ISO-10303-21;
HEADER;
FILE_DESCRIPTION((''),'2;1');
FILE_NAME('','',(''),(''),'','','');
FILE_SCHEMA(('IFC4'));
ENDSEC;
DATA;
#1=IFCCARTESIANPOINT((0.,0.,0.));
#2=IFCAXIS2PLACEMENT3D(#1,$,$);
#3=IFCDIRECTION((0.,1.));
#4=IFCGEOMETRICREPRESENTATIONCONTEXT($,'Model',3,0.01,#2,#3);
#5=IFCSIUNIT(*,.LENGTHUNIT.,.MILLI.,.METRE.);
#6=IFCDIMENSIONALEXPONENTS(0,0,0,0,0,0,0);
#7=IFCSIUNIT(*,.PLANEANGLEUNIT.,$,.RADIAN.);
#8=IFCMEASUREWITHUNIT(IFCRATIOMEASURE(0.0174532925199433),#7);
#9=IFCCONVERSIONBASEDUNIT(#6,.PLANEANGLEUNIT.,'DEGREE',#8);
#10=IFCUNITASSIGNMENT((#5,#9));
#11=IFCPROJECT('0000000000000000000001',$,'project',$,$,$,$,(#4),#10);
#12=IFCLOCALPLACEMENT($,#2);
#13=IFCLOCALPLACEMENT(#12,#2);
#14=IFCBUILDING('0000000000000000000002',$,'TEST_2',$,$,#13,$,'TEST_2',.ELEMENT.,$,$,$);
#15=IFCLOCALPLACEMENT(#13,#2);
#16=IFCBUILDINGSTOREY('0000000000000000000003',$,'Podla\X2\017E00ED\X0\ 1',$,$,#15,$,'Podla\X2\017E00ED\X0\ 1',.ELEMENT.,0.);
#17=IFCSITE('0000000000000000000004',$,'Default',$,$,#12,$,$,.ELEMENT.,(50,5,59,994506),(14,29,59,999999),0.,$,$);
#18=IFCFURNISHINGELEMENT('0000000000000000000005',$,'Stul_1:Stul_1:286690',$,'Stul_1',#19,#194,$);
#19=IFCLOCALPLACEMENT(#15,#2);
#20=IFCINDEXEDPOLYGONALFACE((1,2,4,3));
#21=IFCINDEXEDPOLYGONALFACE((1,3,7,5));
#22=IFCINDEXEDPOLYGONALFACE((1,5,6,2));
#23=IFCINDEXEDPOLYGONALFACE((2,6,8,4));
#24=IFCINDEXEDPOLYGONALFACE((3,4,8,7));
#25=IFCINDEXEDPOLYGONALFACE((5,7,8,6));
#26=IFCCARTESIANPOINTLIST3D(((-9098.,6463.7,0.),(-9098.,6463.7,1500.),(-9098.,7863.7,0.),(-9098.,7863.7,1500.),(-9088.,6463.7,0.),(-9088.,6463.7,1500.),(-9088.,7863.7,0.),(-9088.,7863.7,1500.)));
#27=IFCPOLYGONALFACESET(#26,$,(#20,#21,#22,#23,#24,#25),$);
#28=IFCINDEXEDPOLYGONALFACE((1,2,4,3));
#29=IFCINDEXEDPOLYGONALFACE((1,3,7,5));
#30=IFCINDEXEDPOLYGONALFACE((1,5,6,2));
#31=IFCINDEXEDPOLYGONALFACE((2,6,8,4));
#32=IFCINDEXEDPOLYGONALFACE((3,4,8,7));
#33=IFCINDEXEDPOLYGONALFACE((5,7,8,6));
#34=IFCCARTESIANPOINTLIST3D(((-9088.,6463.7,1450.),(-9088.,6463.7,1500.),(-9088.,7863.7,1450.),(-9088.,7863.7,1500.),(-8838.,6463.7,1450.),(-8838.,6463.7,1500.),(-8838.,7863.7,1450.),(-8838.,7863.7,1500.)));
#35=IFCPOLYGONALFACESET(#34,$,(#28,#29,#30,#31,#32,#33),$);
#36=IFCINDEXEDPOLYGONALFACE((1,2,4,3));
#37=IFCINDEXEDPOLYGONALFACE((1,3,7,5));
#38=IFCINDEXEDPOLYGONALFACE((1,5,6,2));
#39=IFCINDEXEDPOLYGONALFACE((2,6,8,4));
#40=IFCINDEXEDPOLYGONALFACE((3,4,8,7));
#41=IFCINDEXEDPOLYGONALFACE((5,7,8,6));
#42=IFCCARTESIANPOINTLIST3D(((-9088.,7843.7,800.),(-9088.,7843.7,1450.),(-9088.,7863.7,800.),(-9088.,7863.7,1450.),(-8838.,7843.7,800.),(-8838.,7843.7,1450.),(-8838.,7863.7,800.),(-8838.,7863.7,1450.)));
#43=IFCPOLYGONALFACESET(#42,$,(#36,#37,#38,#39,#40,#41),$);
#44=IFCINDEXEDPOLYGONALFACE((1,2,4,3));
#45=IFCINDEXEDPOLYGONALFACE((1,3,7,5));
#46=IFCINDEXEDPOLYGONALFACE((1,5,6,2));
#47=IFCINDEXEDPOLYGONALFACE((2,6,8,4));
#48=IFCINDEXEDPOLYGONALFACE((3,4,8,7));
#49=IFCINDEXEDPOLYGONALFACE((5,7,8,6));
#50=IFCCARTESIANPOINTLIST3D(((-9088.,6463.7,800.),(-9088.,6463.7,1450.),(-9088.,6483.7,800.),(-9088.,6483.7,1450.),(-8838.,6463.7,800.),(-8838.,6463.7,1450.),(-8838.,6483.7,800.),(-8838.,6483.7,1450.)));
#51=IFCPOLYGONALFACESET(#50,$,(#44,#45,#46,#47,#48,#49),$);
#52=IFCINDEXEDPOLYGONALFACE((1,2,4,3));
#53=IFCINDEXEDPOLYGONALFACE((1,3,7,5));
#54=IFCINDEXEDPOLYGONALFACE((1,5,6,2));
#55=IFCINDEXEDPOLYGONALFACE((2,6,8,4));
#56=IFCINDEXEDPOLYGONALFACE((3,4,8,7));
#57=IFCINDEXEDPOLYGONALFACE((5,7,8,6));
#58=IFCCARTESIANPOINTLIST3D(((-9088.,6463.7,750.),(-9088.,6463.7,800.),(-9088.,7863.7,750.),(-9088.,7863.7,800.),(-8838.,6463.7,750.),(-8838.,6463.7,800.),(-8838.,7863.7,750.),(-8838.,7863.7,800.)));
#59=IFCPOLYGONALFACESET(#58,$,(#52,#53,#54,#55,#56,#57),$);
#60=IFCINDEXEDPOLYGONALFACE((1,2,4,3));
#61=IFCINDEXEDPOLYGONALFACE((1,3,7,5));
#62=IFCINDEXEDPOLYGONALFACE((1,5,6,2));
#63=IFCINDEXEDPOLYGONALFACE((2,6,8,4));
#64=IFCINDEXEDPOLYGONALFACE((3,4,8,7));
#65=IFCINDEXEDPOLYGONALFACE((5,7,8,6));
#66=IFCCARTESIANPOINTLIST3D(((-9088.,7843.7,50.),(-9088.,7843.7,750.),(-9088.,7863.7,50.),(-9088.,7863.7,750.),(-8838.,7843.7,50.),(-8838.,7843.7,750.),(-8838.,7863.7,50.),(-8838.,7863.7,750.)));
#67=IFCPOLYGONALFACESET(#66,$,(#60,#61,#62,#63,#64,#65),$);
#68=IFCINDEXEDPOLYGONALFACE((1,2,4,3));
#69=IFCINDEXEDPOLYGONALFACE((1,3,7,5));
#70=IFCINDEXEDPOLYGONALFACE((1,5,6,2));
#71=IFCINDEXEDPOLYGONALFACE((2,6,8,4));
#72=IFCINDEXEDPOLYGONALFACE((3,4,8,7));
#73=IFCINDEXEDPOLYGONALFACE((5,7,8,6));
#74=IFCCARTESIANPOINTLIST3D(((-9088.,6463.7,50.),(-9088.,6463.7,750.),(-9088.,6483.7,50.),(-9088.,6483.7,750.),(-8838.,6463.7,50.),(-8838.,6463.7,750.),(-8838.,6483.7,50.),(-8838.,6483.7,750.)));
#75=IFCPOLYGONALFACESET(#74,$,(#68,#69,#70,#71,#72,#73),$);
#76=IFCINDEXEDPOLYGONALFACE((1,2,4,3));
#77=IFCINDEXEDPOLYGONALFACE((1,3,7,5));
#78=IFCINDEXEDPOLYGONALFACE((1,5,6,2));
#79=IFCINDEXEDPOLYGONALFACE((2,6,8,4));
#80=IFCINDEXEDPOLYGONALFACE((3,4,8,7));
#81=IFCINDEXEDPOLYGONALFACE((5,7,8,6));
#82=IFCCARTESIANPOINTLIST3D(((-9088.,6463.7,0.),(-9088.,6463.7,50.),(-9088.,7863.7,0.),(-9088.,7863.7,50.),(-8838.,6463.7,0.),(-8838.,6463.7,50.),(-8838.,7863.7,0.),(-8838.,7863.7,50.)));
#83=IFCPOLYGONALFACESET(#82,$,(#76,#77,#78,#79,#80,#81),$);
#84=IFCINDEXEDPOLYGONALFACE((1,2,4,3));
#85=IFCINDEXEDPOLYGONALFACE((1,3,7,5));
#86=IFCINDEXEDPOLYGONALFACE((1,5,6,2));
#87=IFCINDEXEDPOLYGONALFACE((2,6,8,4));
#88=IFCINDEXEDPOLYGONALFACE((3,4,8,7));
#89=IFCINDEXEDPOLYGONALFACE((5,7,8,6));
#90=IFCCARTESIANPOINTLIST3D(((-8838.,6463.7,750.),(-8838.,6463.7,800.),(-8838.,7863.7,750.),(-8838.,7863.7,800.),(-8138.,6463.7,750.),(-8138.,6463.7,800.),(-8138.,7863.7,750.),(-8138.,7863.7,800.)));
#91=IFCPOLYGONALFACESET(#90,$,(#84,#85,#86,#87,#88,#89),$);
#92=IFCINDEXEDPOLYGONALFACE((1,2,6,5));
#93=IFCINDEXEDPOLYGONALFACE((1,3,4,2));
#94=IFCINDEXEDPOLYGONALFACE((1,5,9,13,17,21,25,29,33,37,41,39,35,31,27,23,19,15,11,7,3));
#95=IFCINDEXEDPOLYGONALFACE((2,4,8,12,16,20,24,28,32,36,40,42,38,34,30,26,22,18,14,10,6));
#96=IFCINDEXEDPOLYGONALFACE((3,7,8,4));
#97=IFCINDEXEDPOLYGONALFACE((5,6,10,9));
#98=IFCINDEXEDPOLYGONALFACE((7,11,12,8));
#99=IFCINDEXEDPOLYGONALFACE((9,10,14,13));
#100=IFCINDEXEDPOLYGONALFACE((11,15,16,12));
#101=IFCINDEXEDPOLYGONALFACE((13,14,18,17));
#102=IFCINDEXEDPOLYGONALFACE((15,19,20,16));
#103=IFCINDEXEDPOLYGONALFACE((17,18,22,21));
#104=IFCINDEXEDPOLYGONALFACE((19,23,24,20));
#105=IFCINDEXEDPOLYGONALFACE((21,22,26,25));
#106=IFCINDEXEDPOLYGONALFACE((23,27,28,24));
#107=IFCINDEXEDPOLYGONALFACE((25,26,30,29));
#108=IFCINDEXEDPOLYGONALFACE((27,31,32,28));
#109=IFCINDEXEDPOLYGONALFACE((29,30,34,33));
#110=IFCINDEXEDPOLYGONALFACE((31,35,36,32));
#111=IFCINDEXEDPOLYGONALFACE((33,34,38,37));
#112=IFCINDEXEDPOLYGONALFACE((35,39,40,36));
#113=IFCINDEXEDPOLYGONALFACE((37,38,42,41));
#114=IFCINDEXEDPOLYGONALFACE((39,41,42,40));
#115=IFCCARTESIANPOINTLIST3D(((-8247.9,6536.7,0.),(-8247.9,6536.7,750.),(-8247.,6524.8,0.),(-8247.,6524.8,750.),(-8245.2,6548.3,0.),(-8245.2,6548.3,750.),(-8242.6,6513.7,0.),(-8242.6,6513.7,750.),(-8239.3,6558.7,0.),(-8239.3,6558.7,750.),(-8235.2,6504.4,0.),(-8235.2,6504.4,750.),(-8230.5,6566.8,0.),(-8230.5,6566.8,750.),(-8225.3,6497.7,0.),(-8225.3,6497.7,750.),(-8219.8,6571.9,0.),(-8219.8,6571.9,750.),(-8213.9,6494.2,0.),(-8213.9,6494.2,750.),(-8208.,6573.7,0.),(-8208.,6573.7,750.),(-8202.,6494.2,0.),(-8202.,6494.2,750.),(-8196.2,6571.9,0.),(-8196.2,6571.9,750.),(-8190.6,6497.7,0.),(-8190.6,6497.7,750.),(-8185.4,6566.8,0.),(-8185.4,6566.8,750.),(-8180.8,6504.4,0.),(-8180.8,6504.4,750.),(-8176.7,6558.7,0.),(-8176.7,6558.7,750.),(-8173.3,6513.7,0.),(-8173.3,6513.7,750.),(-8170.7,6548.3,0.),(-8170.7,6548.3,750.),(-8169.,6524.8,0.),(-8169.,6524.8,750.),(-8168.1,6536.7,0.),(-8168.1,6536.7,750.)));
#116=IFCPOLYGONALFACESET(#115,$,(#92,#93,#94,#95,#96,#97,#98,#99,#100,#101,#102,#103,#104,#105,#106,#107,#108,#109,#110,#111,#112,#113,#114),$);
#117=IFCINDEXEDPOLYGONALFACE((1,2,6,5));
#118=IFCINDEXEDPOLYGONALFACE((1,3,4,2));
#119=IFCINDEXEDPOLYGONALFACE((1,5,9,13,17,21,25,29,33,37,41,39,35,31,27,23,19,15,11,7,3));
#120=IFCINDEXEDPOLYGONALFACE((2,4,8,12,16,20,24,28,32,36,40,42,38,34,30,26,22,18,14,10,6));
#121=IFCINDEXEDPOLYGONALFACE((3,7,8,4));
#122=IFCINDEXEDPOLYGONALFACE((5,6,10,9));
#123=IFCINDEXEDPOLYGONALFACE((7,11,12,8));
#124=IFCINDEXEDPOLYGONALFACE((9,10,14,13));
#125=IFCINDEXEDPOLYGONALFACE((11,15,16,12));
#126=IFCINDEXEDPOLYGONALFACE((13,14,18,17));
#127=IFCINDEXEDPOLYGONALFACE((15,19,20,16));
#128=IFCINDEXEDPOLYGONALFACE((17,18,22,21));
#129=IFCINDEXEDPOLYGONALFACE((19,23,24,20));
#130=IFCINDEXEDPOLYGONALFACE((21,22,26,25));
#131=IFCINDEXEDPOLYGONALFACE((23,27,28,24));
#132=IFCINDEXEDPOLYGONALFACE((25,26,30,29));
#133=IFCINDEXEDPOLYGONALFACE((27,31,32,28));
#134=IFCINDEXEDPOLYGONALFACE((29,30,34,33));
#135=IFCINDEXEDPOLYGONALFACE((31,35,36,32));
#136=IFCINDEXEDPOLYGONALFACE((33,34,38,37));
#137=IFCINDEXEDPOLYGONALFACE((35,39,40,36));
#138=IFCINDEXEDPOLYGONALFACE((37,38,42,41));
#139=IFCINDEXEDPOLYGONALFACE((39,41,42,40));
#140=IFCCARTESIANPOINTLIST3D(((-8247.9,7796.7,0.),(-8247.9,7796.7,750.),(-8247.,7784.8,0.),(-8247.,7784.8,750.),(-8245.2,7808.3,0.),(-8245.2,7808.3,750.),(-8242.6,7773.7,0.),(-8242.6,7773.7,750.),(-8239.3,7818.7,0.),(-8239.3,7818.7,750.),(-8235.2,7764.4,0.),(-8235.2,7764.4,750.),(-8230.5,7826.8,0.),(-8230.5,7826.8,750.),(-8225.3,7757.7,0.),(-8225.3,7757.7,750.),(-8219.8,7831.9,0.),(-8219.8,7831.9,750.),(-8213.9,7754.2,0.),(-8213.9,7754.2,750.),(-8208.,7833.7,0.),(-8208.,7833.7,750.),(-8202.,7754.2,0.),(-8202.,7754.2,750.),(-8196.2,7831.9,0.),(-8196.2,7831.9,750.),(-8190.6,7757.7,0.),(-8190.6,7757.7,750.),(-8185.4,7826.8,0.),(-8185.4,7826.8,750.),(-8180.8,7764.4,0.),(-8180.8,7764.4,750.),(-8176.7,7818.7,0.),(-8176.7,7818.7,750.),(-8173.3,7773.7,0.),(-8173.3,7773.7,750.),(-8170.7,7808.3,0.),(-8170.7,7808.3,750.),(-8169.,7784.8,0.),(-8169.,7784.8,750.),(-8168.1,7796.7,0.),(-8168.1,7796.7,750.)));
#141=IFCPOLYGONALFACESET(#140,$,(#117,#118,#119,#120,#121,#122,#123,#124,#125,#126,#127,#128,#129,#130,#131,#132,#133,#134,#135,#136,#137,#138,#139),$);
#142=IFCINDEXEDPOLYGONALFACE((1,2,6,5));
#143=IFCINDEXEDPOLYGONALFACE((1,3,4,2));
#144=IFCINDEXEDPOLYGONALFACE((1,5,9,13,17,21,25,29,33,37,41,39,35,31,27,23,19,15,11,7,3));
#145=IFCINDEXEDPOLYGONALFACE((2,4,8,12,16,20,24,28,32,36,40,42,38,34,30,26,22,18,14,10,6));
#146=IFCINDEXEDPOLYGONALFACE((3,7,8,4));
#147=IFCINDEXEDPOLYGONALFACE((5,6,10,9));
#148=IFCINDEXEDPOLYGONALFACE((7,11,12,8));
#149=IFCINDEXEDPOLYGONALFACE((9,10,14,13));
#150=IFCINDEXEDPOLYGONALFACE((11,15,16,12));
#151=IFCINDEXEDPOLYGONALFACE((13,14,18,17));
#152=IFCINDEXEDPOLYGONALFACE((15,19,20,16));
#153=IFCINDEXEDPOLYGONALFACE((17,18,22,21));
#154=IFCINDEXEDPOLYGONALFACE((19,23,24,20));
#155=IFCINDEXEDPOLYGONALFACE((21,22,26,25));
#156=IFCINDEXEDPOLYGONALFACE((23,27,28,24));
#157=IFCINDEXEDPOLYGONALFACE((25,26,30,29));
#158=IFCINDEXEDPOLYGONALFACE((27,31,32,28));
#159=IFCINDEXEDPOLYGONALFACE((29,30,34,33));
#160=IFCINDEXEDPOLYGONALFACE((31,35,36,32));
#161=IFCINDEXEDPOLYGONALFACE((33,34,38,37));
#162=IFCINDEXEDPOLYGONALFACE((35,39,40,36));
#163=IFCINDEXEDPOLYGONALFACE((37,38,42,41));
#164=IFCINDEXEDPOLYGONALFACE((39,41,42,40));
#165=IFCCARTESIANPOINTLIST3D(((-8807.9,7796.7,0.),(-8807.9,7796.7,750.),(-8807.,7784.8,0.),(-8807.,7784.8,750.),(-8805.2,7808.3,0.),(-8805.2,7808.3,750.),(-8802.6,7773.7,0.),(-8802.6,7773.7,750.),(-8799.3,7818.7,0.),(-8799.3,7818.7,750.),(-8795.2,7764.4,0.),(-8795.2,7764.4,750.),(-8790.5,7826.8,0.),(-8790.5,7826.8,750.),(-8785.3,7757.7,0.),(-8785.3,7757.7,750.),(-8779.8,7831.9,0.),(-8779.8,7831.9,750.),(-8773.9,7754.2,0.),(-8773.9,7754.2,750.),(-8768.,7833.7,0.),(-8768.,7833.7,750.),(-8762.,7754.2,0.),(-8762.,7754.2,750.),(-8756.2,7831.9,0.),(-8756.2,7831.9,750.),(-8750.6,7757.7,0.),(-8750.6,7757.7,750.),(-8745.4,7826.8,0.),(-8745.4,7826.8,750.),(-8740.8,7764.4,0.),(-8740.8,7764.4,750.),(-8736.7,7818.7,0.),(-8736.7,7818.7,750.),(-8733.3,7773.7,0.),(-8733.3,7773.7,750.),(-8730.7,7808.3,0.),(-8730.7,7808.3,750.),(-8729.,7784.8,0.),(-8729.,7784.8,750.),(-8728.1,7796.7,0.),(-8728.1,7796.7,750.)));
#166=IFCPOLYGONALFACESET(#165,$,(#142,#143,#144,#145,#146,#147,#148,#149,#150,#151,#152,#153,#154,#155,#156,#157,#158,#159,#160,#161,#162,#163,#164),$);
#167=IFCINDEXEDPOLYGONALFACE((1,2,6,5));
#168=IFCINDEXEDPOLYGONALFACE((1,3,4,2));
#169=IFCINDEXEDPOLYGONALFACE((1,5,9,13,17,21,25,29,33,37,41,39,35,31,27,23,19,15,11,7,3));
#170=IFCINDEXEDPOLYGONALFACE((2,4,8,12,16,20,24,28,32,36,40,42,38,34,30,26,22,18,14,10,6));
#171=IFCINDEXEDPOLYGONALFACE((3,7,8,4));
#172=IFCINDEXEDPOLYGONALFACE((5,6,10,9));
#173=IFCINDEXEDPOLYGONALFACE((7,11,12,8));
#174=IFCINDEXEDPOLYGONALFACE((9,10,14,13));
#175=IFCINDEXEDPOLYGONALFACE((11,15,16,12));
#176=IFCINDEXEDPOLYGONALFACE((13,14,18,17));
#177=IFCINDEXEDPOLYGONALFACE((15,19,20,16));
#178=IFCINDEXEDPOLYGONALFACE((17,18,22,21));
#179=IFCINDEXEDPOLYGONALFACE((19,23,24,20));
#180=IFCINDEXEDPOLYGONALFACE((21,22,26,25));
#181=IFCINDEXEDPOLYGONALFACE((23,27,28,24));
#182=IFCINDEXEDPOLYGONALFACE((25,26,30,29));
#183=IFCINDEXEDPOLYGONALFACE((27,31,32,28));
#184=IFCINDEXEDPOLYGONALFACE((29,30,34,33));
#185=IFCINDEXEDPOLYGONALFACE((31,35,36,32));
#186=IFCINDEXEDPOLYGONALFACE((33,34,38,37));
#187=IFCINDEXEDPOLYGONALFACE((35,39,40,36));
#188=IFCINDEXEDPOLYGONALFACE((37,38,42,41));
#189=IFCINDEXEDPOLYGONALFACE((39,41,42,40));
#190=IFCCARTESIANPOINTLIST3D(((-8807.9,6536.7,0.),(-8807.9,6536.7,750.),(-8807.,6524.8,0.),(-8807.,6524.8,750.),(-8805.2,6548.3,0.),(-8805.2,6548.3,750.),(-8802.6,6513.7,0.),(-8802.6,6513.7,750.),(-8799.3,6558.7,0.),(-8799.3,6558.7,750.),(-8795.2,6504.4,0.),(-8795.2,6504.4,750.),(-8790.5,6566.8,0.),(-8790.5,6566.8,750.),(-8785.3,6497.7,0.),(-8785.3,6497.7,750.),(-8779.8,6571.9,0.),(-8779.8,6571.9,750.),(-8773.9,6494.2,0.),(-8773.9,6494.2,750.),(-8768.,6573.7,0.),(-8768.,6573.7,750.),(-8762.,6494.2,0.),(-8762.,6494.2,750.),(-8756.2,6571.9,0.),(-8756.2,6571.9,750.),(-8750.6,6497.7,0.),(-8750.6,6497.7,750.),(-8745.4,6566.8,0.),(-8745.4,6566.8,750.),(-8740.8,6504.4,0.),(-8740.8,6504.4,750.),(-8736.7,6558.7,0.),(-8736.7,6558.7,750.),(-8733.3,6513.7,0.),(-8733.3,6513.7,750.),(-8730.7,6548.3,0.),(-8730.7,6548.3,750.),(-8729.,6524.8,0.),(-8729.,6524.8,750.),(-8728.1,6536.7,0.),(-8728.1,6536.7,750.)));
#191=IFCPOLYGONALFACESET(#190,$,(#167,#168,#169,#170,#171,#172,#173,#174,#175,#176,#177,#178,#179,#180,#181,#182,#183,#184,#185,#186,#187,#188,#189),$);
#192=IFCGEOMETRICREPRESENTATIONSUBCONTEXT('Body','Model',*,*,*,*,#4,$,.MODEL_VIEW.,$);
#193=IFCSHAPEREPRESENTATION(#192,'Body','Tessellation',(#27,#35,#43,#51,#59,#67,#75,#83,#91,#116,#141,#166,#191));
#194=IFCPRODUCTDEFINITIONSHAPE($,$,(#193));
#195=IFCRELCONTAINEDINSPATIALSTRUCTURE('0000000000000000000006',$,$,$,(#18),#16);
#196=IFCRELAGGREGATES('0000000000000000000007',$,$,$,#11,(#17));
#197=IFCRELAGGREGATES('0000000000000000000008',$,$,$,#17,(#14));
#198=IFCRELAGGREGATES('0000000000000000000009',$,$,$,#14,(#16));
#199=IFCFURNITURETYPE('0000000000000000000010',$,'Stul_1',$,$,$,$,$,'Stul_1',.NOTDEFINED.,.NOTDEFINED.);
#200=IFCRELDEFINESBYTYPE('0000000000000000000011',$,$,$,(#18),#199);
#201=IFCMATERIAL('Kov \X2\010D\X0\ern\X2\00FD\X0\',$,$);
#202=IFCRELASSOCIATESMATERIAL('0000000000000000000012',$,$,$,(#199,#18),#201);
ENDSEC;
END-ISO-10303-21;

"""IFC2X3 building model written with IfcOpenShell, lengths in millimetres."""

from ifc_helpers import new_model, entity, si_unit, converted_unit, direction, frame, frame_2d, origin, origin_2d_with_axis, place, context, subcontext, project, spatial, rectangle, circle, extrude, source, transform, mapped, material, type_object, type_shapes, element, save


model = new_model("IFC2X3")

# Units and contexts
model_context = context("Model", 3, precision=0.01, world=origin(), true_north=direction((0.0, 1.0)))
body_context = subcontext(model_context, "Body", "Model", "MODEL_VIEW")
ifc_project = project(units=[si_unit("LENGTHUNIT", "METRE", prefix="MILLI"), converted_unit("PLANEANGLEUNIT", "DEGREE", entity("IfcRatioMeasure", 0.0174532925199433), si_unit("PLANEANGLEUNIT", "RADIAN"), dimensions=[0, 0, 0, 0, 0, 0, 0])], contexts=[model_context])

# Site, building, storey
site_placement = place(None, origin())
site = spatial("IfcSite", under=ifc_project, at=site_placement, Name="Default", CompositionType="ELEMENT", RefLatitude=(50, 5, 59, 994506), RefLongitude=(14, 29, 59, 999999), RefElevation=0.0)
building_placement = place(site_placement, origin())
building = spatial("IfcBuilding", under=site, at=building_placement, Name="TEST_2", LongName="TEST_2", CompositionType="ELEMENT")
storey_placement = place(building_placement, origin())
storey = spatial("IfcBuildingStorey", under=building, at=storey_placement, Name="Podlaží 1", LongName="Podlaží 1", CompositionType="ELEMENT", Elevation=0.0)

# Furnishing element
ifc_material_1 = material(Name="Kov černý")
furniture_type = type_object("IfcFurnitureType", Name="Stul_1", ElementType="Stul_1", material=ifc_material_1)
shared_shape_1 = source(origin(), body_context, "Body", "SweptSolid", [
    extrude(rectangle(XDim=1400.0, YDim=10.0, at=origin_2d_with_axis()), frame((0.0, 605.0, 0.0), z_axis=(0.0, 0.0, 1.0), x_axis=(-1.0, 0.0, 0.0)), (0.0, 0.0, 1.0), 1500.0),
    extrude(rectangle(XDim=1400.0, YDim=250.0, at=frame_2d((0.0, 0.0), x_axis=(1.0, 0.0))), frame((0.0, 475.0, 1450.0), z_axis=(0.0, 0.0, 1.0), x_axis=(-1.0, 0.0, 0.0)), (0.0, 0.0, 1.0), 50.0),
    extrude(rectangle(XDim=20.0, YDim=250.0, at=origin_2d_with_axis()), frame((690.0, 475.0, 800.0), z_axis=(0.0, 0.0, 1.0), x_axis=(-1.0, 0.0, 0.0)), (0.0, 0.0, 1.0), 650.0),
    extrude(rectangle(XDim=20.0, YDim=250.0, at=frame_2d((0.0, 0.0), x_axis=(1.0, 0.0))), frame((-690.0, 475.0, 800.0), z_axis=(0.0, 0.0, 1.0), x_axis=(-1.0, 0.0, 0.0)), (0.0, 0.0, 1.0), 650.0),
    extrude(rectangle(XDim=1400.0, YDim=250.0, at=origin_2d_with_axis()), frame((0.0, 475.0, 750.0), z_axis=(0.0, 0.0, 1.0), x_axis=(-1.0, 0.0, 0.0)), (0.0, 0.0, 1.0), 50.0),
    extrude(rectangle(XDim=20.0, YDim=250.0, at=origin_2d_with_axis()), frame((690.0, 475.0, 50.0), z_axis=(0.0, 0.0, 1.0), x_axis=(-1.0, 0.0, 0.0)), (0.0, 0.0, 1.0), 700.0),
    extrude(rectangle(XDim=20.0, YDim=250.0, at=frame_2d((0.0, 0.0), x_axis=(1.0, 0.0))), frame((-690.0, 475.0, 50.0), z_axis=(0.0, 0.0, 1.0), x_axis=(-1.0, 0.0, 0.0)), (0.0, 0.0, 1.0), 700.0),
    extrude(rectangle(XDim=1400.0, YDim=250.0, at=origin_2d_with_axis()), frame((0.0, 475.0, 0.0), z_axis=(0.0, 0.0, 1.0), x_axis=(-1.0, 0.0, 0.0)), (0.0, 0.0, 1.0), 50.0),
    extrude(rectangle(XDim=1400.0, YDim=700.0, at=origin_2d_with_axis()), frame((0.0, 0.0, 750.0), z_axis=(0.0, 0.0, 1.0), x_axis=(-1.0, 0.0, 0.0)), (0.0, 0.0, 1.0), 50.0),
    extrude(circle(Radius=40.0, at=frame_2d((0.0, 0.0), x_axis=(1.0, 0.0))), frame((-630.0, -280.0, 0.0)), (0.0, 0.0, 1.0), 750.0),
    extrude(circle(Radius=40.0, at=frame_2d((0.0, 0.0), x_axis=(1.0, 0.0))), frame((630.0, -280.0, 0.0)), (0.0, 0.0, 1.0), 750.0),
    extrude(circle(Radius=40.0, at=frame_2d((0.0, 0.0), x_axis=(1.0, 0.0))), frame((630.0, 280.0, 0.0)), (0.0, 0.0, 1.0), 750.0),
    extrude(circle(Radius=40.0, at=frame_2d((0.0, 0.0), x_axis=(1.0, 0.0))), frame((-630.0, 280.0, 0.0)), (0.0, 0.0, 1.0), 750.0),
])
type_shapes(furniture_type, [shared_shape_1])
for number, where, z_axis, x_axis, name in (
    (1, (-8488.0, 7163.7, 0.0), (0.0, 0.0, 1.0), (0.0, 1.0, 0.0), "Stul_1:Stul_1:286690"),
):
    element("IfcFurnishingElement", number, at=place(storey_placement, frame(where, z_axis=z_axis, x_axis=x_axis)), inside=storey, type_object=furniture_type, material=ifc_material_1, Name=name, ObjectType="Stul_1", context=body_context, shape_type="MappedRepresentation", body=[
        mapped(shared_shape_1, transform((0.0, 0.0, 0.0), scale=1.0)),
    ])

save(model, "model.ifc")
